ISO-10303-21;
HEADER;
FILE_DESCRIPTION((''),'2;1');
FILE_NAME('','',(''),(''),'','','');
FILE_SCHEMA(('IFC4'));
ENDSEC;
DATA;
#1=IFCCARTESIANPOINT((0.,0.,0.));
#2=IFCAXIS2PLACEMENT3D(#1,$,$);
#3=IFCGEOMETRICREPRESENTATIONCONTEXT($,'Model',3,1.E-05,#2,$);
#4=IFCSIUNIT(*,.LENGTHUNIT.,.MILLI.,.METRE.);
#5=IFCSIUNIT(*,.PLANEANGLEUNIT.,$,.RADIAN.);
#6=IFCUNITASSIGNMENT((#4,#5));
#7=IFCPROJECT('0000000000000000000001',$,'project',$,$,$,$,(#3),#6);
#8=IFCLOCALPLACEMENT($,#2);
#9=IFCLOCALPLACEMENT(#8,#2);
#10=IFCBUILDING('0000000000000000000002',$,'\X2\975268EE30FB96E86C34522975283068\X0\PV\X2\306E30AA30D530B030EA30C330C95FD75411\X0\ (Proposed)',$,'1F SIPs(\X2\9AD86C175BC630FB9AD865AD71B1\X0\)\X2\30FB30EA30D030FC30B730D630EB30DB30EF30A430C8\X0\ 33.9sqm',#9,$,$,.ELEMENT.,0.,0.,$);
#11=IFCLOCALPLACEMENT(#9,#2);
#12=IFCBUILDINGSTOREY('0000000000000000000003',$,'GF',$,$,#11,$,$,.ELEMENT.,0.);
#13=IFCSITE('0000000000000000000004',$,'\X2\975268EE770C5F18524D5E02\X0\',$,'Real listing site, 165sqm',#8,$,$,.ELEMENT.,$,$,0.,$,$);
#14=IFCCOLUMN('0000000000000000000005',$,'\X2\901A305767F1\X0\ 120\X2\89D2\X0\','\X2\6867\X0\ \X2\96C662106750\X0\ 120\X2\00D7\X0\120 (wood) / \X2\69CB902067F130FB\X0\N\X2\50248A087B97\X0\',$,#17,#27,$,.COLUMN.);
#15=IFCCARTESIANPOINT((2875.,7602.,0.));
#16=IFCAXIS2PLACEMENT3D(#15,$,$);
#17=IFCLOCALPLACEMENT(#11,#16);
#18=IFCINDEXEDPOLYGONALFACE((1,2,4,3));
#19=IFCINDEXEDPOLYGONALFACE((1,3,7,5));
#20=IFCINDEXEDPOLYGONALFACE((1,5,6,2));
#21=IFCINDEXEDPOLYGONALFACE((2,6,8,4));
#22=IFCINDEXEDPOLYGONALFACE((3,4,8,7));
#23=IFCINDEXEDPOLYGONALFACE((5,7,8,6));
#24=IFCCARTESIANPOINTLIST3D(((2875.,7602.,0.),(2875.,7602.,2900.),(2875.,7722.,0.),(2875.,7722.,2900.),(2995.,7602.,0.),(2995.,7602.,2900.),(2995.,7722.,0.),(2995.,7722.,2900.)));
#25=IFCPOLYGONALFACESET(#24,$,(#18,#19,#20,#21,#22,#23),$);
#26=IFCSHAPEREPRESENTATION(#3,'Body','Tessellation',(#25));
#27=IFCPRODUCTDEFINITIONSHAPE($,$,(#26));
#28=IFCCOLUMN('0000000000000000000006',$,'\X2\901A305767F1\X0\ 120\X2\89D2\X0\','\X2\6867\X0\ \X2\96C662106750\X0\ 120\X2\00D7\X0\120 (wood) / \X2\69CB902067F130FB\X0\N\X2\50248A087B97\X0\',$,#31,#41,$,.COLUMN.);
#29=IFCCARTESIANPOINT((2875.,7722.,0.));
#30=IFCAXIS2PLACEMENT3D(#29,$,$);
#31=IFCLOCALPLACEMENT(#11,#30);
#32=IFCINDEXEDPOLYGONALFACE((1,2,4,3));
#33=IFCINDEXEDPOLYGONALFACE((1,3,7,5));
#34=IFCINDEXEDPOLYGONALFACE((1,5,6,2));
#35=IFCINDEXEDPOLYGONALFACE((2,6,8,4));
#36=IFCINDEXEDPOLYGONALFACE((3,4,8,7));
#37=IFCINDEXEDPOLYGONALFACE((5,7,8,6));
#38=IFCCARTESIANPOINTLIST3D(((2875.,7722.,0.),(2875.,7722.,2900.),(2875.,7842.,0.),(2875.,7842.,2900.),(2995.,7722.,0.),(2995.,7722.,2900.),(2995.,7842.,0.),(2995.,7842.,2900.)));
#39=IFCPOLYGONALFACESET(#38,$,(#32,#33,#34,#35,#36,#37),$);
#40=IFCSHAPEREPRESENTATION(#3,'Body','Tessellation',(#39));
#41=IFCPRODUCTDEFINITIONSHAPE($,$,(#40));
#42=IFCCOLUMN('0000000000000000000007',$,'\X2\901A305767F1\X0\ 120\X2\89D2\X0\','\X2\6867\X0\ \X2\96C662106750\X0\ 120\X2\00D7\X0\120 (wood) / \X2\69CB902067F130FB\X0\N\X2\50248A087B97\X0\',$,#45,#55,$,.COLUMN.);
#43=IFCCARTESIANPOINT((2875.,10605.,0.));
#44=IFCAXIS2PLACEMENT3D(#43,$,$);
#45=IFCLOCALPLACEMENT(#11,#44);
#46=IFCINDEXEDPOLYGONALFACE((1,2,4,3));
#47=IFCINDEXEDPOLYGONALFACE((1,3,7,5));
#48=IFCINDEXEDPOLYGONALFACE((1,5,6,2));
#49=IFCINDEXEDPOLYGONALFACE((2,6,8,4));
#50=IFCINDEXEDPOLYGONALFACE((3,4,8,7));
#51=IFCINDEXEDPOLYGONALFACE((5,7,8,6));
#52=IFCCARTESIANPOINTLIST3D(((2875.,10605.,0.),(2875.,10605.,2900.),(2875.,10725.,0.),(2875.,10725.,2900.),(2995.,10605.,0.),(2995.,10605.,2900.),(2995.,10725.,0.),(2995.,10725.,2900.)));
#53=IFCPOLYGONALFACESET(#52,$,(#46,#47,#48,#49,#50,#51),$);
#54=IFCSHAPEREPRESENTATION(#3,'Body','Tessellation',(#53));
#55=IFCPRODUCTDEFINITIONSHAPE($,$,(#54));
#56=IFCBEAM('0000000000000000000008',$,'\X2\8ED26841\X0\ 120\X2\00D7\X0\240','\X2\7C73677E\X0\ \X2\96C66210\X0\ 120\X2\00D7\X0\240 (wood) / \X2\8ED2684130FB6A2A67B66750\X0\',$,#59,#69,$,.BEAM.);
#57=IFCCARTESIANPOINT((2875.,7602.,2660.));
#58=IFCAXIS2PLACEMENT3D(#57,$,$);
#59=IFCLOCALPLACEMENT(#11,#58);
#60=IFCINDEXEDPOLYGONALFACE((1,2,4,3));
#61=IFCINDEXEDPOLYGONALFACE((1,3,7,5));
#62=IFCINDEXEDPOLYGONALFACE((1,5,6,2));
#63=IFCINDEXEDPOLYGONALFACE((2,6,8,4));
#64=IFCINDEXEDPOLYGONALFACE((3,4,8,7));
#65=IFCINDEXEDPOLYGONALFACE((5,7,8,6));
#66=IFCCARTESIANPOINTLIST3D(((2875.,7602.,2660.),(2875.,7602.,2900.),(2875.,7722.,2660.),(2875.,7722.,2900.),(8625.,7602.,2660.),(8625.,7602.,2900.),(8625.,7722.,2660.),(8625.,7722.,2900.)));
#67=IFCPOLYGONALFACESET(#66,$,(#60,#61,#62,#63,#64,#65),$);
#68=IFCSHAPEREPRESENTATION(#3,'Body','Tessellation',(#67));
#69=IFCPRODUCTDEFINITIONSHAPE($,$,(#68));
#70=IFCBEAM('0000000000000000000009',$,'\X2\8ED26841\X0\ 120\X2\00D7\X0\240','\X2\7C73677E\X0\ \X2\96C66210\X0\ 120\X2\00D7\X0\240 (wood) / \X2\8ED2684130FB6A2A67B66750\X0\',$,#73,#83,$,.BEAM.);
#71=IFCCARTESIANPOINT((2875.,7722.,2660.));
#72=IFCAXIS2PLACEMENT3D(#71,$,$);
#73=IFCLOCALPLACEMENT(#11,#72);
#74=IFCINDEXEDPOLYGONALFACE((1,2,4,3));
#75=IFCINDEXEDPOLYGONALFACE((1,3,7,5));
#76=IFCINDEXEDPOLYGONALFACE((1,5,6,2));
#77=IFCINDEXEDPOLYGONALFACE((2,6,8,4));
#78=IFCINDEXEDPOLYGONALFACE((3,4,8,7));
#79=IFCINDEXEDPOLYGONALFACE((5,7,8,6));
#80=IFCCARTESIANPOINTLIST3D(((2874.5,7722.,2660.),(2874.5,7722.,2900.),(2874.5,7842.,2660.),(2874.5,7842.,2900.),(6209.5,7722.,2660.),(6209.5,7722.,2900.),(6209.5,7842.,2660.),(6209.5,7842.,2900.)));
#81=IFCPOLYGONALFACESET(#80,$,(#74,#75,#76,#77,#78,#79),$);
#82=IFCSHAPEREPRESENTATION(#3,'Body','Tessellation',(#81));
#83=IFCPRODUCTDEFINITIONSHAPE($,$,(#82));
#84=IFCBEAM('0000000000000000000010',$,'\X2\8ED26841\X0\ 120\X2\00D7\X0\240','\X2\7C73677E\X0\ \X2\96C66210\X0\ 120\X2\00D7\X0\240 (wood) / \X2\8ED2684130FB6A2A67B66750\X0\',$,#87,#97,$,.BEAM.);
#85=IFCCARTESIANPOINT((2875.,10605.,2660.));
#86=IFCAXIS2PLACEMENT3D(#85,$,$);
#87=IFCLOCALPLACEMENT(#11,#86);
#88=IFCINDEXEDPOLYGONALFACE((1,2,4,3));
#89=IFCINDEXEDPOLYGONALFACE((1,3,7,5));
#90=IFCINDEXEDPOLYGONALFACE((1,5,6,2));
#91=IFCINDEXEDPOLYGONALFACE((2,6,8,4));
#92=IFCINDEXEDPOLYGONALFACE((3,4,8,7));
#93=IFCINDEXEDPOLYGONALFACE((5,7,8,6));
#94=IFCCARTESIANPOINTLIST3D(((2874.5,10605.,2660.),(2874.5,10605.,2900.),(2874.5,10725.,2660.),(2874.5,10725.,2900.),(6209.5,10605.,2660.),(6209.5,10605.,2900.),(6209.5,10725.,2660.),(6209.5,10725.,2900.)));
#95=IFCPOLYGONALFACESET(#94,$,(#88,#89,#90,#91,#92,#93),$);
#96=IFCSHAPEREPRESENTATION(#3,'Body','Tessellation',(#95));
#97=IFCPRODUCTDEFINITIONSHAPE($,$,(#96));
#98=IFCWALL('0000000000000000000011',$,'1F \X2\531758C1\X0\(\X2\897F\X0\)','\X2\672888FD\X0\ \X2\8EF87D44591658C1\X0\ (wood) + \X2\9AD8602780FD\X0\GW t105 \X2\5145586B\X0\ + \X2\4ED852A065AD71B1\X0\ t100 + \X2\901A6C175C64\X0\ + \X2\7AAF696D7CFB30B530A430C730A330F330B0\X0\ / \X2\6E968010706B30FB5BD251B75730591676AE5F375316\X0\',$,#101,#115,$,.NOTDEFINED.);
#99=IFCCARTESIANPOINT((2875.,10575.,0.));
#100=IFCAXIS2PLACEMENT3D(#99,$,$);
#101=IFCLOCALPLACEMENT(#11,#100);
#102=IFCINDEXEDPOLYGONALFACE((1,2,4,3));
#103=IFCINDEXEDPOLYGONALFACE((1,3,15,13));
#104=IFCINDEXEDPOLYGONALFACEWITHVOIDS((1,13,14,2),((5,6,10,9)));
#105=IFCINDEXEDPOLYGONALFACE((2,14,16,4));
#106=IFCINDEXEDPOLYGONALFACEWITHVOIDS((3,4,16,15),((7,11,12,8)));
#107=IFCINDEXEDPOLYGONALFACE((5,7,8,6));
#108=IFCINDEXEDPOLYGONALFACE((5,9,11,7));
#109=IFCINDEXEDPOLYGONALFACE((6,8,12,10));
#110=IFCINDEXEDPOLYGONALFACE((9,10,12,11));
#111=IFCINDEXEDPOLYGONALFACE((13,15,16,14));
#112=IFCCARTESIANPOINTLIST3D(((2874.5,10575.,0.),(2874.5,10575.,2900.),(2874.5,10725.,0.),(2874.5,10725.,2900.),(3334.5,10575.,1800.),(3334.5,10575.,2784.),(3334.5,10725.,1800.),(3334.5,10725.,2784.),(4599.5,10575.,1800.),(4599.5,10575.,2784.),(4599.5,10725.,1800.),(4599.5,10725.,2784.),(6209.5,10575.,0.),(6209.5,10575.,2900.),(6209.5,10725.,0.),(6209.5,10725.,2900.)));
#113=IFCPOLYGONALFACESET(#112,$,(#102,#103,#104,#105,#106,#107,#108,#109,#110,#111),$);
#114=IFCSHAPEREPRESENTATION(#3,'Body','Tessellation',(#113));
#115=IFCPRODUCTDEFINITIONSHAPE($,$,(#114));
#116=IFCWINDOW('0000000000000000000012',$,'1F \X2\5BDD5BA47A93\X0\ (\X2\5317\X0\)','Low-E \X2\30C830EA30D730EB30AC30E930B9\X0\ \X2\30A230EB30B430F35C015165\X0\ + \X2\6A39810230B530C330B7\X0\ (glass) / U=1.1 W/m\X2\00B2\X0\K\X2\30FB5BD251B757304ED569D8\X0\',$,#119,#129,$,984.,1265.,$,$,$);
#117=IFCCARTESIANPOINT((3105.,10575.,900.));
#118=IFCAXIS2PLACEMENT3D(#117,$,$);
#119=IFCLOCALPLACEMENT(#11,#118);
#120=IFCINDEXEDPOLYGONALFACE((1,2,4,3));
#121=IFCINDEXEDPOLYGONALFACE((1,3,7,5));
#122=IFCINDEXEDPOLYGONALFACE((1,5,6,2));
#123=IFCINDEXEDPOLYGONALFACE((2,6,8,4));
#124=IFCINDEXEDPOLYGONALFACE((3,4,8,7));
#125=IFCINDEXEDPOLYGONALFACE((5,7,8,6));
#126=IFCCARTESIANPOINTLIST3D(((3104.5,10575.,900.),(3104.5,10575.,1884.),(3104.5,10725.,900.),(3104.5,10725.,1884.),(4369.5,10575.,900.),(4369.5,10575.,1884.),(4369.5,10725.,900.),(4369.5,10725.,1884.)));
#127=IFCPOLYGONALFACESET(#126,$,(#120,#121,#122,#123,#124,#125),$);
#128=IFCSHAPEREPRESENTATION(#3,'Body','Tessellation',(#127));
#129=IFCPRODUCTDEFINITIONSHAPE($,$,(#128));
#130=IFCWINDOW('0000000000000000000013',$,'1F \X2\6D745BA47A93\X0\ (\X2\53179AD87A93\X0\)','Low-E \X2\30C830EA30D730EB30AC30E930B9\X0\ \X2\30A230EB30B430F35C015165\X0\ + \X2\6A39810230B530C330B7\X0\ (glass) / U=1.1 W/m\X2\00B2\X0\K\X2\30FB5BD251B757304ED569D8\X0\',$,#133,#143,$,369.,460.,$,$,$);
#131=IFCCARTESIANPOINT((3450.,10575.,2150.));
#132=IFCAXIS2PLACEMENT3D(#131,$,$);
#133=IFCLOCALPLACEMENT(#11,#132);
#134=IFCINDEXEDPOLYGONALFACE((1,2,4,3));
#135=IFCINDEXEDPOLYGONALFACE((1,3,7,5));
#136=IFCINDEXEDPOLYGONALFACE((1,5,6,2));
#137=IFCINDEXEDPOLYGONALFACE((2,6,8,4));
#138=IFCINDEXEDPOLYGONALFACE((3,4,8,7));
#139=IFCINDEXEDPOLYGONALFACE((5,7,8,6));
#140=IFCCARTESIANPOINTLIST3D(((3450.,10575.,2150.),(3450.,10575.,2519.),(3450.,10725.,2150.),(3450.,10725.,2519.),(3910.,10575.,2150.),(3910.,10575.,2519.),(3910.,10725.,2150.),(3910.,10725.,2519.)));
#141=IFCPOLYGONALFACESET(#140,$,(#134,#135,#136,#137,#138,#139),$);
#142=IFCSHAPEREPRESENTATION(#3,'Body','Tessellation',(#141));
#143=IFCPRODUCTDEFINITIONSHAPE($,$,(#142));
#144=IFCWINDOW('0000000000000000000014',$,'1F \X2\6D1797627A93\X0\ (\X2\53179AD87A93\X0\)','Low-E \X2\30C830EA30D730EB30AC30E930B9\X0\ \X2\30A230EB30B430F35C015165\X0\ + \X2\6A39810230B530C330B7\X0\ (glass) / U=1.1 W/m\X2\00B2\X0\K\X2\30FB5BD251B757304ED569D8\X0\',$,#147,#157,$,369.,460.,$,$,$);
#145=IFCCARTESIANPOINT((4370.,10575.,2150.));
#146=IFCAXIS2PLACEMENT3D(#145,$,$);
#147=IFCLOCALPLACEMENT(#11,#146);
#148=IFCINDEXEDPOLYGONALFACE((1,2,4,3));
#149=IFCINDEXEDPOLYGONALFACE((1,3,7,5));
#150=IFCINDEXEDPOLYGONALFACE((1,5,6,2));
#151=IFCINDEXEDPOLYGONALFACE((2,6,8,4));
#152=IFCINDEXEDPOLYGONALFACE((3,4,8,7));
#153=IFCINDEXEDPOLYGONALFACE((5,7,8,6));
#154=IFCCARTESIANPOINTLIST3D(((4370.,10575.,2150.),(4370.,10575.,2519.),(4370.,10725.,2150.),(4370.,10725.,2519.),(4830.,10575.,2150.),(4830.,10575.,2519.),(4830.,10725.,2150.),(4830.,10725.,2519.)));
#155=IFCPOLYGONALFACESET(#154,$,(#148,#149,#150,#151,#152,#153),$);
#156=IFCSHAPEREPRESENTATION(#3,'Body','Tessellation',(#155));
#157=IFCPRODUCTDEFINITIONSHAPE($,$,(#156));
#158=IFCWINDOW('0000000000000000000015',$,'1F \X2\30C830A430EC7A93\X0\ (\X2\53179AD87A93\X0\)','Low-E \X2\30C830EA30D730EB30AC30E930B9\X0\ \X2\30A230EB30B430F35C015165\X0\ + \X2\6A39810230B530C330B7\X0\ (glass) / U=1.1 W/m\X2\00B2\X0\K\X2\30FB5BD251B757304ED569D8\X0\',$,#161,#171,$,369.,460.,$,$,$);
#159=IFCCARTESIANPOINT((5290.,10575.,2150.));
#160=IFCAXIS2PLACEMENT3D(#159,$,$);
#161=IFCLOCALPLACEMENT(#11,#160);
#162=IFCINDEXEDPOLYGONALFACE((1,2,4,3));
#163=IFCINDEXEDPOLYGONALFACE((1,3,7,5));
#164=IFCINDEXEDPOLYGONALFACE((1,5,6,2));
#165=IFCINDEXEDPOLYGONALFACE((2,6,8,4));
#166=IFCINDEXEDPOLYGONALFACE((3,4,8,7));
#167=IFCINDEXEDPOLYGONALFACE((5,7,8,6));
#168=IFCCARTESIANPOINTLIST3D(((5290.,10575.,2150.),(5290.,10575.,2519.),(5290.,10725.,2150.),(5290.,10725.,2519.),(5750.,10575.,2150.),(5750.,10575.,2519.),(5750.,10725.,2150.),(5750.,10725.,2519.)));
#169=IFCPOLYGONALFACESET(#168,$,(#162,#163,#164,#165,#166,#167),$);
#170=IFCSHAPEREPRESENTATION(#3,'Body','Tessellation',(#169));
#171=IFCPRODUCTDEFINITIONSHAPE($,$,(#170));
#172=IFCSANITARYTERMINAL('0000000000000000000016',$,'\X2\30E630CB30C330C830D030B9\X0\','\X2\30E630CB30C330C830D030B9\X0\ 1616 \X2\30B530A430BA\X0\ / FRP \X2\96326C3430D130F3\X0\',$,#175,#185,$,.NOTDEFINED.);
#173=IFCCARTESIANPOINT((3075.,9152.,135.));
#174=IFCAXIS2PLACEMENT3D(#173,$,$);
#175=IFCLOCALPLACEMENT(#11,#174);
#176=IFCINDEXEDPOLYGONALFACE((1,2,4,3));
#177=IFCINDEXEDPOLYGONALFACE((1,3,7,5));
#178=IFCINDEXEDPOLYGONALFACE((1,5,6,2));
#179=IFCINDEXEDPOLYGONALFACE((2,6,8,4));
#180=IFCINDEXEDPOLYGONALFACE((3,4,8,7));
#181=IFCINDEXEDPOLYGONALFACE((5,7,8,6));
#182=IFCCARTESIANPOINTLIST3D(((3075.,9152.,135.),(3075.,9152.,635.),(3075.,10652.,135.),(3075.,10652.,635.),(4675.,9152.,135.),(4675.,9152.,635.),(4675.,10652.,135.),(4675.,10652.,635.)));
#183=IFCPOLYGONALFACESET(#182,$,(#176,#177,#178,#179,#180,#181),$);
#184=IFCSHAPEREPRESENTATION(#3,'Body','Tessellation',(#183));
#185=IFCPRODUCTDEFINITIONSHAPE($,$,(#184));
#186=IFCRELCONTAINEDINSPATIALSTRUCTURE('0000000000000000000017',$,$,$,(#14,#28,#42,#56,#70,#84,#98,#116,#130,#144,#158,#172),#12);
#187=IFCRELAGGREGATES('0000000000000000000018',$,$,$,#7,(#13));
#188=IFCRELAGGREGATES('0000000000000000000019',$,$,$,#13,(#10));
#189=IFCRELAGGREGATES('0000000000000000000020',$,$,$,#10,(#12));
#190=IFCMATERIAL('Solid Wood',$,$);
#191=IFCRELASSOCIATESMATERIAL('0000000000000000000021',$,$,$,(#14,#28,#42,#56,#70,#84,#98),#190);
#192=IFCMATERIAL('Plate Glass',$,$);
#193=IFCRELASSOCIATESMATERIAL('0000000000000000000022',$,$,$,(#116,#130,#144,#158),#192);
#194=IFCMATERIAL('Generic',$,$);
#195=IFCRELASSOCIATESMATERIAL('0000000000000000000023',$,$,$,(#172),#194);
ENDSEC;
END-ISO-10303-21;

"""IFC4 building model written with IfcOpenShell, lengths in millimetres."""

from ifc_helpers import new_model, si_unit, frame, frame_2d, origin, place, context, project, spatial, rectangle, extrude, material, element, fill, save


model = new_model("IFC4")

# Units and contexts
model_context = context("Model", 3, precision=1e-05, world=origin())
ifc_project = project(units=[si_unit("LENGTHUNIT", "METRE", prefix="MILLI"), si_unit("PLANEANGLEUNIT", "RADIAN")], contexts=[model_context])

# Site, building, storey
site_placement = place(None, origin())
site = spatial("IfcSite", under=ifc_project, at=site_placement, Name="青森県弘前市", ObjectType="Real listing site, 165sqm", CompositionType="ELEMENT", RefElevation=0.0)
building_placement = place(site_placement, origin())
building = spatial("IfcBuilding", under=site, at=building_placement, Name="青森・雨水利用とPVのオフグリッド志向 (Proposed)", ObjectType="1F SIPs(高気密・高断熱)・リバーシブルホワイト 33.9sqm", CompositionType="ELEMENT", ElevationOfRefHeight=0.0, ElevationOfTerrain=0.0)
storey_placement = place(building_placement, origin())
storey = spatial("IfcBuildingStorey", under=building, at=storey_placement, Name="GF", CompositionType="ELEMENT", Elevation=0.0)

# Columns
ifc_material_1 = material(Name="Solid Wood")
column_1_placement = place(storey_placement, frame((2875.0, 7602.0, 0.0)))
element("IfcColumn", 1, at=column_1_placement, inside=storey, material=ifc_material_1, Name="通し柱 120角", Description="桧 集成材 120×120 (wood) / 構造柱・N値計算", PredefinedType="COLUMN", context=model_context, shape_type="SweptSolid", body=[
    extrude(rectangle(XDim=120.0, YDim=120.0, at=frame_2d((60.0, 60.0))), frame((2875.0, 7602.0, 0.0)), (0.0, 0.0, 1.0), 2900.0),
])
column_2_placement = place(storey_placement, frame((2875.0, 7722.0, 0.0)))
element("IfcColumn", 2, at=column_2_placement, inside=storey, material=ifc_material_1, Name="通し柱 120角", Description="桧 集成材 120×120 (wood) / 構造柱・N値計算", PredefinedType="COLUMN", context=model_context, shape_type="SweptSolid", body=[
    extrude(rectangle(XDim=120.0, YDim=120.0, at=frame_2d((60.0, 60.0))), frame((2875.0, 7722.0, 0.0)), (0.0, 0.0, 1.0), 2900.0),
])
column_3_placement = place(storey_placement, frame((2875.0, 10605.0, 0.0)))
element("IfcColumn", 3, at=column_3_placement, inside=storey, material=ifc_material_1, Name="通し柱 120角", Description="桧 集成材 120×120 (wood) / 構造柱・N値計算", PredefinedType="COLUMN", context=model_context, shape_type="SweptSolid", body=[
    extrude(rectangle(XDim=120.0, YDim=120.0, at=frame_2d((60.0, 60.0))), frame((2875.0, 10605.0, 0.0)), (0.0, 0.0, 1.0), 2900.0),
])

# Beams
beam_1_placement = place(storey_placement, frame((2875.0, 7602.0, 2660.0)))
element("IfcBeam", 4, at=beam_1_placement, inside=storey, material=ifc_material_1, Name="軒桁 120×240", Description="米松 集成 120×240 (wood) / 軒桁・横架材", PredefinedType="BEAM", context=model_context, shape_type="SweptSolid", body=[
    extrude(rectangle(XDim=5750.0, YDim=120.0, at=frame_2d((2875.0, 60.0))), frame((2875.0, 7602.0, 2660.0)), (0.0, 0.0, 1.0), 240.0),
])
beam_2_placement = place(storey_placement, frame((2875.0, 7722.0, 2660.0)))
element("IfcBeam", 5, at=beam_2_placement, inside=storey, material=ifc_material_1, Name="軒桁 120×240", Description="米松 集成 120×240 (wood) / 軒桁・横架材", PredefinedType="BEAM", context=model_context, shape_type="SweptSolid", body=[
    extrude(rectangle(XDim=3335.0, YDim=120.0, at=frame_2d((1667.0, 60.0))), frame((2875.0, 7722.0, 2660.0)), (0.0, 0.0, 1.0), 240.0),
])
beam_3_placement = place(storey_placement, frame((2875.0, 10605.0, 2660.0)))
element("IfcBeam", 6, at=beam_3_placement, inside=storey, material=ifc_material_1, Name="軒桁 120×240", Description="米松 集成 120×240 (wood) / 軒桁・横架材", PredefinedType="BEAM", context=model_context, shape_type="SweptSolid", body=[
    extrude(rectangle(XDim=3335.0, YDim=120.0, at=frame_2d((1667.0, 60.0))), frame((2875.0, 10605.0, 2660.0)), (0.0, 0.0, 1.0), 240.0),
])

# Wall, openings, windows
wall_1_placement = place(storey_placement, frame((2875.0, 10575.0, 0.0)))
wall_1 = element("IfcWall", 7, at=wall_1_placement, inside=storey, material=ifc_material_1, Name="1F 北壁(西)", Description="木製 軸組外壁 (wood) + 高性能GW t105 充填 + 付加断熱 t100 + 通気層 + 窯業系サイディング / 準耐火・寒冷地外皮強化", PredefinedType="NOTDEFINED", context=model_context, shape_type="SweptSolid", body=[
    extrude(rectangle(XDim=3335.0, YDim=150.0, at=frame_2d((1667.0, 75.0))), frame((2875.0, 10575.0, 0.0)), (0.0, 0.0, 1.0), 2900.0),
])
opening_1_placement = place(storey_placement, frame((3105.0, 10575.0, 900.0)))
opening_1 = element("IfcOpeningElement", 8, at=opening_1_placement, cuts=wall_1, PredefinedType="NOTDEFINED", context=model_context, shape_type="SweptSolid", body=[
    extrude(rectangle(XDim=1265.0, YDim=150.0, at=frame_2d((632.0, 75.0))), frame((3105.0, 10575.0, 900.0)), (0.0, 0.0, 1.0), 984.0),
])
opening_2_placement = place(storey_placement, frame((3450.0, 10575.0, 2150.0)))
opening_2 = element("IfcOpeningElement", 9, at=opening_2_placement, cuts=wall_1, PredefinedType="NOTDEFINED", context=model_context, shape_type="SweptSolid", body=[
    extrude(rectangle(XDim=460.0, YDim=150.0, at=frame_2d((230.0, 75.0))), frame((3450.0, 10575.0, 2150.0)), (0.0, 0.0, 1.0), 369.0),
])
opening_3_placement = place(storey_placement, frame((4370.0, 10575.0, 2150.0)))
opening_3 = element("IfcOpeningElement", 10, at=opening_3_placement, cuts=wall_1, PredefinedType="NOTDEFINED", context=model_context, shape_type="SweptSolid", body=[
    extrude(rectangle(XDim=460.0, YDim=150.0, at=frame_2d((230.0, 75.0))), frame((4370.0, 10575.0, 2150.0)), (0.0, 0.0, 1.0), 369.0),
])
opening_4_placement = place(storey_placement, frame((5290.0, 10575.0, 2150.0)))
opening_4 = element("IfcOpeningElement", 11, at=opening_4_placement, cuts=wall_1, PredefinedType="NOTDEFINED", context=model_context, shape_type="SweptSolid", body=[
    extrude(rectangle(XDim=460.0, YDim=150.0, at=frame_2d((230.0, 75.0))), frame((5290.0, 10575.0, 2150.0)), (0.0, 0.0, 1.0), 369.0),
])
ifc_material_2 = material(Name="Plate Glass")
window_1_placement = place(storey_placement, frame((3105.0, 10575.0, 900.0)))
window_1 = element("IfcWindow", 12, at=window_1_placement, inside=storey, material=ifc_material_2, Name="1F 寝室窓 (北)", Description="Low-E トリプルガラス アルゴン封入 + 樹脂サッシ (glass) / U=1.1 W/m²K・寒冷地仕様", OverallHeight=984.0, OverallWidth=1265.0, context=model_context, shape_type="SweptSolid", body=[
    extrude(rectangle(XDim=1265.0, YDim=150.0, at=frame_2d((632.0, 75.0))), frame((3105.0, 10575.0, 900.0)), (0.0, 0.0, 1.0), 984.0),
])
fill(opening_1, window_1)
window_2_placement = place(storey_placement, frame((3450.0, 10575.0, 2150.0)))
window_2 = element("IfcWindow", 13, at=window_2_placement, inside=storey, material=ifc_material_2, Name="1F 浴室窓 (北高窓)", Description="Low-E トリプルガラス アルゴン封入 + 樹脂サッシ (glass) / U=1.1 W/m²K・寒冷地仕様", OverallHeight=369.0, OverallWidth=460.0, context=model_context, shape_type="SweptSolid", body=[
    extrude(rectangle(XDim=460.0, YDim=150.0, at=frame_2d((230.0, 75.0))), frame((3450.0, 10575.0, 2150.0)), (0.0, 0.0, 1.0), 369.0),
])
fill(opening_2, window_2)
window_3_placement = place(storey_placement, frame((4370.0, 10575.0, 2150.0)))
window_3 = element("IfcWindow", 14, at=window_3_placement, inside=storey, material=ifc_material_2, Name="1F 洗面窓 (北高窓)", Description="Low-E トリプルガラス アルゴン封入 + 樹脂サッシ (glass) / U=1.1 W/m²K・寒冷地仕様", OverallHeight=369.0, OverallWidth=460.0, context=model_context, shape_type="SweptSolid", body=[
    extrude(rectangle(XDim=460.0, YDim=150.0, at=frame_2d((230.0, 75.0))), frame((4370.0, 10575.0, 2150.0)), (0.0, 0.0, 1.0), 369.0),
])
fill(opening_3, window_3)
window_4_placement = place(storey_placement, frame((5290.0, 10575.0, 2150.0)))
window_4 = element("IfcWindow", 15, at=window_4_placement, inside=storey, material=ifc_material_2, Name="1F トイレ窓 (北高窓)", Description="Low-E トリプルガラス アルゴン封入 + 樹脂サッシ (glass) / U=1.1 W/m²K・寒冷地仕様", OverallHeight=369.0, OverallWidth=460.0, context=model_context, shape_type="SweptSolid", body=[
    extrude(rectangle(XDim=460.0, YDim=150.0, at=frame_2d((230.0, 75.0))), frame((5290.0, 10575.0, 2150.0)), (0.0, 0.0, 1.0), 369.0),
])
fill(opening_4, window_4)

# Shared definitions
ifc_material_3 = material(Name="Generic")

# Sanitary terminal
sanitary_terminal_placement = place(storey_placement, frame((3075.0, 9152.0, 135.0)))
element("IfcSanitaryTerminal", 16, at=sanitary_terminal_placement, inside=storey, material=ifc_material_3, Name="ユニットバス", Description="ユニットバス 1616 サイズ / FRP 防水パン", PredefinedType="NOTDEFINED", context=model_context, shape_type="SweptSolid", body=[
    extrude(rectangle(XDim=1600.0, YDim=1500.0, at=frame_2d((800.0, 750.0))), frame((3075.0, 9152.0, 135.0)), (0.0, 0.0, 1.0), 500.0),
])

save(model, "model.ifc")
